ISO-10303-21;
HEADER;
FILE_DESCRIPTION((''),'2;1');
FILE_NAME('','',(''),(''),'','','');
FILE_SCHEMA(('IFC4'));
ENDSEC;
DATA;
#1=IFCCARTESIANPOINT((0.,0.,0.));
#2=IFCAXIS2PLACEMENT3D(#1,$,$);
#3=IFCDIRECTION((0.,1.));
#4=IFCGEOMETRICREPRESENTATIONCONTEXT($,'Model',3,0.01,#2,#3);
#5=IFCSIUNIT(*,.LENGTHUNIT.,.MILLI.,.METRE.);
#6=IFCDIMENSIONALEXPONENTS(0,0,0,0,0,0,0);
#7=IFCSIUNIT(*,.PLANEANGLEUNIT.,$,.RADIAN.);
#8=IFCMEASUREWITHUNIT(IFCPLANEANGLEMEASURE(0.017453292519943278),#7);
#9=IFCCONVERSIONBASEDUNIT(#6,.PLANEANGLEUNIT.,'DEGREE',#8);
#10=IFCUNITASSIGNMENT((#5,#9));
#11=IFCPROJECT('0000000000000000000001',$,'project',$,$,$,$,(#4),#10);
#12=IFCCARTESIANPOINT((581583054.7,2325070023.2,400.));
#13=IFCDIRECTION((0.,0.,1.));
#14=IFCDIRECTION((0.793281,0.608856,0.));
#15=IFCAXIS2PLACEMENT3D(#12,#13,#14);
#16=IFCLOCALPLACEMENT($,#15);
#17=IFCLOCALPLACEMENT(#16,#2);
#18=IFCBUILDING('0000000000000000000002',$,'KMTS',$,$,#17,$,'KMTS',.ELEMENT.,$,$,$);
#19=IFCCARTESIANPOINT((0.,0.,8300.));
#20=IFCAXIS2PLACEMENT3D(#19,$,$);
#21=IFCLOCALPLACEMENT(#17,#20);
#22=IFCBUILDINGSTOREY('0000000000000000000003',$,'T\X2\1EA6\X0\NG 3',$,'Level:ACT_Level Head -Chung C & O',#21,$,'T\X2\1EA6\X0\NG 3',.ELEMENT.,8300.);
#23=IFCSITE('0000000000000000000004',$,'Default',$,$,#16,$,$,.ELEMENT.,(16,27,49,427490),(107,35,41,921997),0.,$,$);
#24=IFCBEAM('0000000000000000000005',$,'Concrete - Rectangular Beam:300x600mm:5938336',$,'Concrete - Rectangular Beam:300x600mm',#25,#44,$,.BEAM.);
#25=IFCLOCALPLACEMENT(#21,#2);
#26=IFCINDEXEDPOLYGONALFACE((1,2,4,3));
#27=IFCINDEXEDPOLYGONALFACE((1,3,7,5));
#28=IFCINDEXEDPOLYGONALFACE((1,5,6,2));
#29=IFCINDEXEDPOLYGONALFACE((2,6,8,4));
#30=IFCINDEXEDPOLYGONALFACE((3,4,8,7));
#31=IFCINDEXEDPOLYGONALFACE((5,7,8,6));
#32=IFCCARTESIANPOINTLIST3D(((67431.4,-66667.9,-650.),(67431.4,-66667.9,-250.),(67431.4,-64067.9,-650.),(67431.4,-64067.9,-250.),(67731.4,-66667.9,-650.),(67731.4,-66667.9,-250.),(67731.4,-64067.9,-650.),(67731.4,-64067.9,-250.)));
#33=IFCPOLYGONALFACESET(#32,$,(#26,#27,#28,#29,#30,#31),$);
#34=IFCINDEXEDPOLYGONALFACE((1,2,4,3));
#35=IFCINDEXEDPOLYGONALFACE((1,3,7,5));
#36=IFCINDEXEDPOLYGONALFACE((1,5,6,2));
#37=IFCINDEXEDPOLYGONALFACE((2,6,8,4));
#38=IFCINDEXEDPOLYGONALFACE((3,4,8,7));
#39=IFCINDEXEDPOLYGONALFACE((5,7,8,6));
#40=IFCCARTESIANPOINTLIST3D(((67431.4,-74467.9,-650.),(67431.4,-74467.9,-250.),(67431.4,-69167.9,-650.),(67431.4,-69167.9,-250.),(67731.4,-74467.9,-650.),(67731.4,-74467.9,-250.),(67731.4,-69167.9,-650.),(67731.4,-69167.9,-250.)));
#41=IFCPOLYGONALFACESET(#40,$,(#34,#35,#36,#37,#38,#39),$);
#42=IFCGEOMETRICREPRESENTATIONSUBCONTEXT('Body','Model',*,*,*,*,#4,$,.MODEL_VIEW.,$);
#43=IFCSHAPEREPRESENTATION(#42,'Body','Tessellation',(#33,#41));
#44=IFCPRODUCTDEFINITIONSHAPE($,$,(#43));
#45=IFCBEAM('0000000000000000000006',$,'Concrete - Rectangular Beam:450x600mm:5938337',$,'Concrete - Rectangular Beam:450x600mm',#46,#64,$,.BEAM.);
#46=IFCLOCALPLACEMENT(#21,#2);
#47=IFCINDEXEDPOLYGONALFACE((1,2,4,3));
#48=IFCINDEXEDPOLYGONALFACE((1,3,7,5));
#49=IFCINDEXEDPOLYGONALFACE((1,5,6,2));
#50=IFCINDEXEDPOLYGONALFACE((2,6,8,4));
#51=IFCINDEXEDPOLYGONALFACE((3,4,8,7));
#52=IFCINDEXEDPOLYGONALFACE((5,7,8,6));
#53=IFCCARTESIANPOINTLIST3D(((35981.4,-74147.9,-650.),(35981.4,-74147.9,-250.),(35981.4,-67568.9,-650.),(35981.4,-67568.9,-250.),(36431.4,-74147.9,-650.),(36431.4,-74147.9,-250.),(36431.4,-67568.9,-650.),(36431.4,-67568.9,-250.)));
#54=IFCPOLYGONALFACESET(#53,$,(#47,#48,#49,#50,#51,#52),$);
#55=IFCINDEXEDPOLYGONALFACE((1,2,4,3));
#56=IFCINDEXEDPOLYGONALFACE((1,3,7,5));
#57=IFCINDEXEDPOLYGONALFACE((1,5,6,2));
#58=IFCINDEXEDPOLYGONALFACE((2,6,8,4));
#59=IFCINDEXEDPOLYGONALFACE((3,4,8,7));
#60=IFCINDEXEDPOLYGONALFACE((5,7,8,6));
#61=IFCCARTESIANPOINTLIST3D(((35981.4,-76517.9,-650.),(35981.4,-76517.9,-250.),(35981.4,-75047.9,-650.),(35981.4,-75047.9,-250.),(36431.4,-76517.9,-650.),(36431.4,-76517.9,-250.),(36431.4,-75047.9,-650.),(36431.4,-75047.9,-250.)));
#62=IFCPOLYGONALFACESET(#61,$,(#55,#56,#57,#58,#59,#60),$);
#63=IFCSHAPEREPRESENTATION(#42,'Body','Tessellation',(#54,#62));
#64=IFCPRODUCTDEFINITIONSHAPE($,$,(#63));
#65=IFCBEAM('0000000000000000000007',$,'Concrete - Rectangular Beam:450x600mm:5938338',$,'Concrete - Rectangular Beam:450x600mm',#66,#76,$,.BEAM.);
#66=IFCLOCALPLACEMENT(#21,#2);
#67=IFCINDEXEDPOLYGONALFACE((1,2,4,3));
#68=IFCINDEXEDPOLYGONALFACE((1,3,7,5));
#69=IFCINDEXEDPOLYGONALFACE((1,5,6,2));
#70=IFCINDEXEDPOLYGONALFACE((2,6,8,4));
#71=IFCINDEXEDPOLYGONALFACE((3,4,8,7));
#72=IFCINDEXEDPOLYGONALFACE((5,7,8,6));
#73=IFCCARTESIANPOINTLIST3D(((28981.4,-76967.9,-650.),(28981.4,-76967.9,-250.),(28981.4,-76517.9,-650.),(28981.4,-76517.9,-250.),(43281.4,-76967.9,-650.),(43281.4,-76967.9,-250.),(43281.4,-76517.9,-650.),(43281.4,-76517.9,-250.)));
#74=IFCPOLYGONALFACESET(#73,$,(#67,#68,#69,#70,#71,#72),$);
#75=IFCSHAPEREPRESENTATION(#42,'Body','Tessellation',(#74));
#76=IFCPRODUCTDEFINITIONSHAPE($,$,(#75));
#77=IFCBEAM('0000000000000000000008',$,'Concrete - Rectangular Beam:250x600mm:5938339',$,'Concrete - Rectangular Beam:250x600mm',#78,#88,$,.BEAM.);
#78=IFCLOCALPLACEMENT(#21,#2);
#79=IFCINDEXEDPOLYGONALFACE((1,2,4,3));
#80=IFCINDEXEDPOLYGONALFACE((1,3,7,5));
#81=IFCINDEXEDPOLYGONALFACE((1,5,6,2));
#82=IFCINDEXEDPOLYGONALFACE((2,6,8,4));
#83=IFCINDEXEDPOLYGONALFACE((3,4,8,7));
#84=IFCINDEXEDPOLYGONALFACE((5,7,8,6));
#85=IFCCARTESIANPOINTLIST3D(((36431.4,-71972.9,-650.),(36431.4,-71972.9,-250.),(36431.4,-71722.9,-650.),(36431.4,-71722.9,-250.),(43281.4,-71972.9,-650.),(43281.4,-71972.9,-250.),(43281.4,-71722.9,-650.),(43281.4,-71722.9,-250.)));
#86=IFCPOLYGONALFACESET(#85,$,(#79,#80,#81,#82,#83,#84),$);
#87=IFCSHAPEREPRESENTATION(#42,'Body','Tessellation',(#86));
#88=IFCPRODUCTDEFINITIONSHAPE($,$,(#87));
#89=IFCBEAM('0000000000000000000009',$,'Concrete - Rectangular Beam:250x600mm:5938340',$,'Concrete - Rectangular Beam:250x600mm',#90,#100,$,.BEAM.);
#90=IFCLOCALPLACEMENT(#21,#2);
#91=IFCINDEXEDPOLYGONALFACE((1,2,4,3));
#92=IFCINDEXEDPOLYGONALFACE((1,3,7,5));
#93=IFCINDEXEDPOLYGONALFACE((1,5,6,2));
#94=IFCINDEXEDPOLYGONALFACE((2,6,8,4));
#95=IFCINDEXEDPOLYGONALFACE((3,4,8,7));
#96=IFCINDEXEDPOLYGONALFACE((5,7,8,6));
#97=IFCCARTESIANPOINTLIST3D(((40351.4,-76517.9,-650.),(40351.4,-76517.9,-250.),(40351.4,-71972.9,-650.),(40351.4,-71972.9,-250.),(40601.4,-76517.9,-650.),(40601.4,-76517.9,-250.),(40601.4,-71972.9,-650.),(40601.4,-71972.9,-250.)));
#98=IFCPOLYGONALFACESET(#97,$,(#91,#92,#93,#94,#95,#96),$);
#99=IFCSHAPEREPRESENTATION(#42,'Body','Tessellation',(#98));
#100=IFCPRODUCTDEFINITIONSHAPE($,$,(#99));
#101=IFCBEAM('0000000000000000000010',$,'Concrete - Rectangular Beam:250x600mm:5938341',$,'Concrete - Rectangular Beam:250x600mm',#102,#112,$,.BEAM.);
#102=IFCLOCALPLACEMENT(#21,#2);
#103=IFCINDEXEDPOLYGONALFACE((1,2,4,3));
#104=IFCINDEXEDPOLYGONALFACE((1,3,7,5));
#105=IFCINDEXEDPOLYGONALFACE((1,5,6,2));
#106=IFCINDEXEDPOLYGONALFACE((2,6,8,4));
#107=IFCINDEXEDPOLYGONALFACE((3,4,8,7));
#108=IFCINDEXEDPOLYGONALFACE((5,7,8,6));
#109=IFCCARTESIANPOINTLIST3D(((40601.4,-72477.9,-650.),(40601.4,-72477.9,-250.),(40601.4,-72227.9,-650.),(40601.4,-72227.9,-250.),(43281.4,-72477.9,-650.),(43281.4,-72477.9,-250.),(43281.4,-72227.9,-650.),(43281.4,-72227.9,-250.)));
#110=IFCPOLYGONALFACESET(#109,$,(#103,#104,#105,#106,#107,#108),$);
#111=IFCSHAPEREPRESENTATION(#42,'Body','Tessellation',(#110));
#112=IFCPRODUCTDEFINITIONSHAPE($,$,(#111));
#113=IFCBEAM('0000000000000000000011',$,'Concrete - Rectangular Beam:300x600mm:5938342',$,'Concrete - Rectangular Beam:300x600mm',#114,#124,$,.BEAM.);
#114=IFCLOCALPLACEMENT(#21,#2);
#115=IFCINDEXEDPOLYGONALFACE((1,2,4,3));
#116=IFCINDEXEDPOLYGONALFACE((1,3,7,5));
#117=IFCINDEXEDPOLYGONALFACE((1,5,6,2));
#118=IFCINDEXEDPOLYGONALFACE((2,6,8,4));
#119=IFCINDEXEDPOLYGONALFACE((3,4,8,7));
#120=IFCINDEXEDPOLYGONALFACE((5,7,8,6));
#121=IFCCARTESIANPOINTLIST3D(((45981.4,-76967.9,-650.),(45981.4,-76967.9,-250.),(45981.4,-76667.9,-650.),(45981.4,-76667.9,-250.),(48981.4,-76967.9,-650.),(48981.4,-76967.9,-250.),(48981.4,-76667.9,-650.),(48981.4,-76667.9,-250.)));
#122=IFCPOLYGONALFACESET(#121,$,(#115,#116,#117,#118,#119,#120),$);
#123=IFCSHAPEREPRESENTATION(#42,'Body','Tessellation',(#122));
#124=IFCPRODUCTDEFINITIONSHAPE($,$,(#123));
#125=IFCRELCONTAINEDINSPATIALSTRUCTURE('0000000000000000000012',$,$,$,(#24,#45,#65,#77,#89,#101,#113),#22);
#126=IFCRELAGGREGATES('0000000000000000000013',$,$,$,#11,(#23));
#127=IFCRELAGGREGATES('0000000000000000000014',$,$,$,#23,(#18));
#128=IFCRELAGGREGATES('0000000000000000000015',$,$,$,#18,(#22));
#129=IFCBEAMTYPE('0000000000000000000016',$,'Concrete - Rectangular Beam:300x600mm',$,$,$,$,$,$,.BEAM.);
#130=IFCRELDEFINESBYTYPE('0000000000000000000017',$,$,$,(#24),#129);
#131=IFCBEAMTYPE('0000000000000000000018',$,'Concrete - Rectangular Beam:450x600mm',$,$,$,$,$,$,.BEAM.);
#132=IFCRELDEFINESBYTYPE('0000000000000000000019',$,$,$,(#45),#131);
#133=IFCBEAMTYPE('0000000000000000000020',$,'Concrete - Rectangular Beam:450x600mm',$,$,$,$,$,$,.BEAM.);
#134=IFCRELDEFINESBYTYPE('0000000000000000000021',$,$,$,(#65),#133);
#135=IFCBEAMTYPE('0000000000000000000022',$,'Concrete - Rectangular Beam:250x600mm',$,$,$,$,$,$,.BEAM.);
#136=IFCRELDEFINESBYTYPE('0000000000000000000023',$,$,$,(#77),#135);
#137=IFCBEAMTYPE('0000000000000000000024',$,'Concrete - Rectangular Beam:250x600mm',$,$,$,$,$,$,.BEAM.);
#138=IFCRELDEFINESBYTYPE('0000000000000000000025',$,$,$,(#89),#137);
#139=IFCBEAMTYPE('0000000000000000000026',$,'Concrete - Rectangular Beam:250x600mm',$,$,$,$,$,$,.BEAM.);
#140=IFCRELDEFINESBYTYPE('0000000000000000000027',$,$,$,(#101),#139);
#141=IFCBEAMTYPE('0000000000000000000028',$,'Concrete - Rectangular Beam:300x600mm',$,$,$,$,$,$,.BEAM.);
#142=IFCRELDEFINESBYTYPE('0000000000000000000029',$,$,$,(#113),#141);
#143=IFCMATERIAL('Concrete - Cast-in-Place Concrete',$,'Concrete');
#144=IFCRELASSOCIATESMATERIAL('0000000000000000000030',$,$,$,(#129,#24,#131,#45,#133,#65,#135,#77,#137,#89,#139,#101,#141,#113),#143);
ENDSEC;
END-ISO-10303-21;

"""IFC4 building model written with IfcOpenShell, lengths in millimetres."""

from ifc_helpers import new_model, entity, si_unit, converted_unit, direction, frame, origin, place, context, subcontext, project, spatial, indexed_curve, outline, extrude, source, transform, mapped, material, type_object, type_shapes, element, save


model = new_model("IFC4")

# Units and contexts
model_context = context("Model", 3, precision=0.01, world=origin(), true_north=direction((0.0, 1.0)))
body_context = subcontext(model_context, "Body", "Model", "MODEL_VIEW")
ifc_project = project(units=[si_unit("LENGTHUNIT", "METRE", prefix="MILLI"), converted_unit("PLANEANGLEUNIT", "DEGREE", entity("IfcPlaneAngleMeasure", 0.017453292519943278), si_unit("PLANEANGLEUNIT", "RADIAN"), dimensions=[0, 0, 0, 0, 0, 0, 0])], contexts=[model_context])

# Site, building, storey
site_placement = place(None, frame((581583054.7, 2325070023.2, 400.0), z_axis=(0.0, 0.0, 1.0), x_axis=(0.793281, 0.608856, 0.0)))
site = spatial("IfcSite", under=ifc_project, at=site_placement, Name="Default", CompositionType="ELEMENT", RefLatitude=(16, 27, 49, 427490), RefLongitude=(107, 35, 41, 921997), RefElevation=0.0)
building_placement = place(site_placement, origin())
building = spatial("IfcBuilding", under=site, at=building_placement, Name="KMTS", LongName="KMTS", CompositionType="ELEMENT")
storey_placement = place(building_placement, frame((0.0, 0.0, 8300.0)))
storey = spatial("IfcBuildingStorey", under=building, at=storey_placement, Name="TẦNG 3", ObjectType="Level:ACT_Level Head -Chung C & O", LongName="TẦNG 3", CompositionType="ELEMENT", Elevation=8300.0)

# Beams
ifc_material_1 = material(Name="Concrete - Cast-in-Place Concrete", Category="Concrete")
beam_type_1 = type_object("IfcBeamType", Name="Concrete - Rectangular Beam:300x600mm", PredefinedType="BEAM", material=ifc_material_1)
shared_shape_1 = source(origin(), body_context, "Body", "SweptSolid", [
    extrude(outline(indexed_curve([(-150.0, -200.0), (150.0, -200.0), (150.0, 200.0), (-150.0, 200.0), (-150.0, -200.0)], self_intersect=False)), frame((67581.4, -66667.9, 7850.0), z_axis=(0.0, 1.0, 0.0), x_axis=(-1.0, 0.0, 0.0)), (0.0, 0.0, 1.0), 2600.0),
    extrude(outline(indexed_curve([(-150.0, -200.0), (150.0, -200.0), (150.0, 200.0), (-150.0, 200.0), (-150.0, -200.0)], self_intersect=False)), frame((67581.4, -74467.9, 7850.0), z_axis=(0.0, 1.0, 0.0), x_axis=(-1.0, 0.0, 0.0)), (0.0, 0.0, 1.0), 5300.0),
])
type_shapes(beam_type_1, [shared_shape_1])
beam_1_placement = place(storey_placement, frame((0.0, 0.0, -8300.0)))
element("IfcBeam", 1, at=beam_1_placement, inside=storey, type_object=beam_type_1, material=ifc_material_1, Name="Concrete - Rectangular Beam:300x600mm:5938336", ObjectType="Concrete - Rectangular Beam:300x600mm", PredefinedType="BEAM", context=body_context, shape_type="MappedRepresentation", body=[
    mapped(shared_shape_1, transform((0.0, 0.0, 0.0), scale=1.0)),
])
beam_type_2 = type_object("IfcBeamType", Name="Concrete - Rectangular Beam:450x600mm", PredefinedType="BEAM", material=ifc_material_1)
shared_shape_2 = source(origin(), body_context, "Body", "SweptSolid", [
    extrude(outline(indexed_curve([(-225.0, -200.0), (225.0, -200.0), (225.0, 200.0), (-225.0, 200.0), (-225.0, -200.0)], self_intersect=False)), frame((36206.4, -74147.9, 7850.0), z_axis=(0.0, 1.0, 0.0), x_axis=(-1.0, 0.0, 0.0)), (0.0, 0.0, 1.0), 6579.0),
    extrude(outline(indexed_curve([(-225.0, -200.0), (225.0, -200.0), (225.0, 200.0), (-225.0, 200.0), (-225.0, -200.0)], self_intersect=False)), frame((36206.4, -76517.9, 7850.0), z_axis=(0.0, 1.0, 0.0), x_axis=(-1.0, 0.0, 0.0)), (0.0, 0.0, 1.0), 1470.0),
])
type_shapes(beam_type_2, [shared_shape_2])
beam_2_placement = place(storey_placement, frame((0.0, 0.0, -8300.0)))
element("IfcBeam", 2, at=beam_2_placement, inside=storey, type_object=beam_type_2, material=ifc_material_1, Name="Concrete - Rectangular Beam:450x600mm:5938337", ObjectType="Concrete - Rectangular Beam:450x600mm", PredefinedType="BEAM", context=body_context, shape_type="MappedRepresentation", body=[
    mapped(shared_shape_2, transform((0.0, 0.0, 0.0), scale=1.0)),
])
beam_type_3 = type_object("IfcBeamType", Name="Concrete - Rectangular Beam:450x600mm", PredefinedType="BEAM", material=ifc_material_1)
shared_shape_3 = source(origin(), body_context, "Body", "SweptSolid", [
    extrude(outline(indexed_curve([(-200.0, -225.0), (200.0, -225.0), (200.0, 225.0), (-200.0, 225.0), (-200.0, -225.0)], self_intersect=False)), frame((28981.4, -76742.9, 7850.0), z_axis=(1.0, 0.0, 0.0), x_axis=(0.0, 0.0, -1.0)), (0.0, 0.0, 1.0), 14300.0),
])
type_shapes(beam_type_3, [shared_shape_3])
beam_3_placement = place(storey_placement, frame((0.0, 0.0, -8300.0)))
element("IfcBeam", 3, at=beam_3_placement, inside=storey, type_object=beam_type_3, material=ifc_material_1, Name="Concrete - Rectangular Beam:450x600mm:5938338", ObjectType="Concrete - Rectangular Beam:450x600mm", PredefinedType="BEAM", context=body_context, shape_type="MappedRepresentation", body=[
    mapped(shared_shape_3, transform((0.0, 0.0, 0.0), scale=1.0)),
])
beam_type_4 = type_object("IfcBeamType", Name="Concrete - Rectangular Beam:250x600mm", PredefinedType="BEAM", material=ifc_material_1)
shared_shape_4 = source(origin(), body_context, "Body", "SweptSolid", [
    extrude(outline(indexed_curve([(-200.0, -125.0), (200.0, -125.0), (200.0, 125.0), (-200.0, 125.0), (-200.0, -125.0)], self_intersect=False)), frame((36431.4, -71847.9, 7850.0), z_axis=(1.0, 0.0, 0.0), x_axis=(0.0, 0.0, -1.0)), (0.0, 0.0, 1.0), 6850.0),
])
type_shapes(beam_type_4, [shared_shape_4])
beam_4_placement = place(storey_placement, frame((0.0, 0.0, -8300.0)))
element("IfcBeam", 4, at=beam_4_placement, inside=storey, type_object=beam_type_4, material=ifc_material_1, Name="Concrete - Rectangular Beam:250x600mm:5938339", ObjectType="Concrete - Rectangular Beam:250x600mm", PredefinedType="BEAM", context=body_context, shape_type="MappedRepresentation", body=[
    mapped(shared_shape_4, transform((0.0, 0.0, 0.0), scale=1.0)),
])
beam_type_5 = type_object("IfcBeamType", Name="Concrete - Rectangular Beam:250x600mm", PredefinedType="BEAM", material=ifc_material_1)
shared_shape_5 = source(origin(), body_context, "Body", "SweptSolid", [
    extrude(outline(indexed_curve([(-125.0, -200.0), (125.0, -200.0), (125.0, 200.0), (-125.0, 200.0), (-125.0, -200.0)], self_intersect=False)), frame((40476.4, -76517.9, 7850.0), z_axis=(0.0, 1.0, 0.0), x_axis=(-1.0, 0.0, 0.0)), (0.0, 0.0, 1.0), 4545.0),
])
type_shapes(beam_type_5, [shared_shape_5])
beam_5_placement = place(storey_placement, frame((0.0, 0.0, -8300.0)))
element("IfcBeam", 5, at=beam_5_placement, inside=storey, type_object=beam_type_5, material=ifc_material_1, Name="Concrete - Rectangular Beam:250x600mm:5938340", ObjectType="Concrete - Rectangular Beam:250x600mm", PredefinedType="BEAM", context=body_context, shape_type="MappedRepresentation", body=[
    mapped(shared_shape_5, transform((0.0, 0.0, 0.0), scale=1.0)),
])
beam_type_6 = type_object("IfcBeamType", Name="Concrete - Rectangular Beam:250x600mm", PredefinedType="BEAM", material=ifc_material_1)
shared_shape_6 = source(origin(), body_context, "Body", "SweptSolid", [
    extrude(outline(indexed_curve([(-200.0, -125.0), (200.0, -125.0), (200.0, 125.0), (-200.0, 125.0), (-200.0, -125.0)], self_intersect=False)), frame((40601.4, -72352.9, 7850.0), z_axis=(1.0, 0.0, 0.0), x_axis=(0.0, 0.0, -1.0)), (0.0, 0.0, 1.0), 2680.0),
])
type_shapes(beam_type_6, [shared_shape_6])
beam_6_placement = place(storey_placement, frame((0.0, 0.0, -8300.0)))
element("IfcBeam", 6, at=beam_6_placement, inside=storey, type_object=beam_type_6, material=ifc_material_1, Name="Concrete - Rectangular Beam:250x600mm:5938341", ObjectType="Concrete - Rectangular Beam:250x600mm", PredefinedType="BEAM", context=body_context, shape_type="MappedRepresentation", body=[
    mapped(shared_shape_6, transform((0.0, 0.0, 0.0), scale=1.0)),
])
beam_type_7 = type_object("IfcBeamType", Name="Concrete - Rectangular Beam:300x600mm", PredefinedType="BEAM", material=ifc_material_1)
shared_shape_7 = source(origin(), body_context, "Body", "SweptSolid", [
    extrude(outline(indexed_curve([(-200.0, -150.0), (200.0, -150.0), (200.0, 150.0), (-200.0, 150.0), (-200.0, -150.0)], self_intersect=False)), frame((45981.4, -76817.9, 7850.0), z_axis=(1.0, 0.0, 0.0), x_axis=(0.0, 0.0, -1.0)), (0.0, 0.0, 1.0), 3000.0),
])
type_shapes(beam_type_7, [shared_shape_7])
beam_7_placement = place(storey_placement, frame((0.0, 0.0, -8300.0)))
element("IfcBeam", 7, at=beam_7_placement, inside=storey, type_object=beam_type_7, material=ifc_material_1, Name="Concrete - Rectangular Beam:300x600mm:5938342", ObjectType="Concrete - Rectangular Beam:300x600mm", PredefinedType="BEAM", context=body_context, shape_type="MappedRepresentation", body=[
    mapped(shared_shape_7, transform((0.0, 0.0, 0.0), scale=1.0)),
])

save(model, "model.ifc")
